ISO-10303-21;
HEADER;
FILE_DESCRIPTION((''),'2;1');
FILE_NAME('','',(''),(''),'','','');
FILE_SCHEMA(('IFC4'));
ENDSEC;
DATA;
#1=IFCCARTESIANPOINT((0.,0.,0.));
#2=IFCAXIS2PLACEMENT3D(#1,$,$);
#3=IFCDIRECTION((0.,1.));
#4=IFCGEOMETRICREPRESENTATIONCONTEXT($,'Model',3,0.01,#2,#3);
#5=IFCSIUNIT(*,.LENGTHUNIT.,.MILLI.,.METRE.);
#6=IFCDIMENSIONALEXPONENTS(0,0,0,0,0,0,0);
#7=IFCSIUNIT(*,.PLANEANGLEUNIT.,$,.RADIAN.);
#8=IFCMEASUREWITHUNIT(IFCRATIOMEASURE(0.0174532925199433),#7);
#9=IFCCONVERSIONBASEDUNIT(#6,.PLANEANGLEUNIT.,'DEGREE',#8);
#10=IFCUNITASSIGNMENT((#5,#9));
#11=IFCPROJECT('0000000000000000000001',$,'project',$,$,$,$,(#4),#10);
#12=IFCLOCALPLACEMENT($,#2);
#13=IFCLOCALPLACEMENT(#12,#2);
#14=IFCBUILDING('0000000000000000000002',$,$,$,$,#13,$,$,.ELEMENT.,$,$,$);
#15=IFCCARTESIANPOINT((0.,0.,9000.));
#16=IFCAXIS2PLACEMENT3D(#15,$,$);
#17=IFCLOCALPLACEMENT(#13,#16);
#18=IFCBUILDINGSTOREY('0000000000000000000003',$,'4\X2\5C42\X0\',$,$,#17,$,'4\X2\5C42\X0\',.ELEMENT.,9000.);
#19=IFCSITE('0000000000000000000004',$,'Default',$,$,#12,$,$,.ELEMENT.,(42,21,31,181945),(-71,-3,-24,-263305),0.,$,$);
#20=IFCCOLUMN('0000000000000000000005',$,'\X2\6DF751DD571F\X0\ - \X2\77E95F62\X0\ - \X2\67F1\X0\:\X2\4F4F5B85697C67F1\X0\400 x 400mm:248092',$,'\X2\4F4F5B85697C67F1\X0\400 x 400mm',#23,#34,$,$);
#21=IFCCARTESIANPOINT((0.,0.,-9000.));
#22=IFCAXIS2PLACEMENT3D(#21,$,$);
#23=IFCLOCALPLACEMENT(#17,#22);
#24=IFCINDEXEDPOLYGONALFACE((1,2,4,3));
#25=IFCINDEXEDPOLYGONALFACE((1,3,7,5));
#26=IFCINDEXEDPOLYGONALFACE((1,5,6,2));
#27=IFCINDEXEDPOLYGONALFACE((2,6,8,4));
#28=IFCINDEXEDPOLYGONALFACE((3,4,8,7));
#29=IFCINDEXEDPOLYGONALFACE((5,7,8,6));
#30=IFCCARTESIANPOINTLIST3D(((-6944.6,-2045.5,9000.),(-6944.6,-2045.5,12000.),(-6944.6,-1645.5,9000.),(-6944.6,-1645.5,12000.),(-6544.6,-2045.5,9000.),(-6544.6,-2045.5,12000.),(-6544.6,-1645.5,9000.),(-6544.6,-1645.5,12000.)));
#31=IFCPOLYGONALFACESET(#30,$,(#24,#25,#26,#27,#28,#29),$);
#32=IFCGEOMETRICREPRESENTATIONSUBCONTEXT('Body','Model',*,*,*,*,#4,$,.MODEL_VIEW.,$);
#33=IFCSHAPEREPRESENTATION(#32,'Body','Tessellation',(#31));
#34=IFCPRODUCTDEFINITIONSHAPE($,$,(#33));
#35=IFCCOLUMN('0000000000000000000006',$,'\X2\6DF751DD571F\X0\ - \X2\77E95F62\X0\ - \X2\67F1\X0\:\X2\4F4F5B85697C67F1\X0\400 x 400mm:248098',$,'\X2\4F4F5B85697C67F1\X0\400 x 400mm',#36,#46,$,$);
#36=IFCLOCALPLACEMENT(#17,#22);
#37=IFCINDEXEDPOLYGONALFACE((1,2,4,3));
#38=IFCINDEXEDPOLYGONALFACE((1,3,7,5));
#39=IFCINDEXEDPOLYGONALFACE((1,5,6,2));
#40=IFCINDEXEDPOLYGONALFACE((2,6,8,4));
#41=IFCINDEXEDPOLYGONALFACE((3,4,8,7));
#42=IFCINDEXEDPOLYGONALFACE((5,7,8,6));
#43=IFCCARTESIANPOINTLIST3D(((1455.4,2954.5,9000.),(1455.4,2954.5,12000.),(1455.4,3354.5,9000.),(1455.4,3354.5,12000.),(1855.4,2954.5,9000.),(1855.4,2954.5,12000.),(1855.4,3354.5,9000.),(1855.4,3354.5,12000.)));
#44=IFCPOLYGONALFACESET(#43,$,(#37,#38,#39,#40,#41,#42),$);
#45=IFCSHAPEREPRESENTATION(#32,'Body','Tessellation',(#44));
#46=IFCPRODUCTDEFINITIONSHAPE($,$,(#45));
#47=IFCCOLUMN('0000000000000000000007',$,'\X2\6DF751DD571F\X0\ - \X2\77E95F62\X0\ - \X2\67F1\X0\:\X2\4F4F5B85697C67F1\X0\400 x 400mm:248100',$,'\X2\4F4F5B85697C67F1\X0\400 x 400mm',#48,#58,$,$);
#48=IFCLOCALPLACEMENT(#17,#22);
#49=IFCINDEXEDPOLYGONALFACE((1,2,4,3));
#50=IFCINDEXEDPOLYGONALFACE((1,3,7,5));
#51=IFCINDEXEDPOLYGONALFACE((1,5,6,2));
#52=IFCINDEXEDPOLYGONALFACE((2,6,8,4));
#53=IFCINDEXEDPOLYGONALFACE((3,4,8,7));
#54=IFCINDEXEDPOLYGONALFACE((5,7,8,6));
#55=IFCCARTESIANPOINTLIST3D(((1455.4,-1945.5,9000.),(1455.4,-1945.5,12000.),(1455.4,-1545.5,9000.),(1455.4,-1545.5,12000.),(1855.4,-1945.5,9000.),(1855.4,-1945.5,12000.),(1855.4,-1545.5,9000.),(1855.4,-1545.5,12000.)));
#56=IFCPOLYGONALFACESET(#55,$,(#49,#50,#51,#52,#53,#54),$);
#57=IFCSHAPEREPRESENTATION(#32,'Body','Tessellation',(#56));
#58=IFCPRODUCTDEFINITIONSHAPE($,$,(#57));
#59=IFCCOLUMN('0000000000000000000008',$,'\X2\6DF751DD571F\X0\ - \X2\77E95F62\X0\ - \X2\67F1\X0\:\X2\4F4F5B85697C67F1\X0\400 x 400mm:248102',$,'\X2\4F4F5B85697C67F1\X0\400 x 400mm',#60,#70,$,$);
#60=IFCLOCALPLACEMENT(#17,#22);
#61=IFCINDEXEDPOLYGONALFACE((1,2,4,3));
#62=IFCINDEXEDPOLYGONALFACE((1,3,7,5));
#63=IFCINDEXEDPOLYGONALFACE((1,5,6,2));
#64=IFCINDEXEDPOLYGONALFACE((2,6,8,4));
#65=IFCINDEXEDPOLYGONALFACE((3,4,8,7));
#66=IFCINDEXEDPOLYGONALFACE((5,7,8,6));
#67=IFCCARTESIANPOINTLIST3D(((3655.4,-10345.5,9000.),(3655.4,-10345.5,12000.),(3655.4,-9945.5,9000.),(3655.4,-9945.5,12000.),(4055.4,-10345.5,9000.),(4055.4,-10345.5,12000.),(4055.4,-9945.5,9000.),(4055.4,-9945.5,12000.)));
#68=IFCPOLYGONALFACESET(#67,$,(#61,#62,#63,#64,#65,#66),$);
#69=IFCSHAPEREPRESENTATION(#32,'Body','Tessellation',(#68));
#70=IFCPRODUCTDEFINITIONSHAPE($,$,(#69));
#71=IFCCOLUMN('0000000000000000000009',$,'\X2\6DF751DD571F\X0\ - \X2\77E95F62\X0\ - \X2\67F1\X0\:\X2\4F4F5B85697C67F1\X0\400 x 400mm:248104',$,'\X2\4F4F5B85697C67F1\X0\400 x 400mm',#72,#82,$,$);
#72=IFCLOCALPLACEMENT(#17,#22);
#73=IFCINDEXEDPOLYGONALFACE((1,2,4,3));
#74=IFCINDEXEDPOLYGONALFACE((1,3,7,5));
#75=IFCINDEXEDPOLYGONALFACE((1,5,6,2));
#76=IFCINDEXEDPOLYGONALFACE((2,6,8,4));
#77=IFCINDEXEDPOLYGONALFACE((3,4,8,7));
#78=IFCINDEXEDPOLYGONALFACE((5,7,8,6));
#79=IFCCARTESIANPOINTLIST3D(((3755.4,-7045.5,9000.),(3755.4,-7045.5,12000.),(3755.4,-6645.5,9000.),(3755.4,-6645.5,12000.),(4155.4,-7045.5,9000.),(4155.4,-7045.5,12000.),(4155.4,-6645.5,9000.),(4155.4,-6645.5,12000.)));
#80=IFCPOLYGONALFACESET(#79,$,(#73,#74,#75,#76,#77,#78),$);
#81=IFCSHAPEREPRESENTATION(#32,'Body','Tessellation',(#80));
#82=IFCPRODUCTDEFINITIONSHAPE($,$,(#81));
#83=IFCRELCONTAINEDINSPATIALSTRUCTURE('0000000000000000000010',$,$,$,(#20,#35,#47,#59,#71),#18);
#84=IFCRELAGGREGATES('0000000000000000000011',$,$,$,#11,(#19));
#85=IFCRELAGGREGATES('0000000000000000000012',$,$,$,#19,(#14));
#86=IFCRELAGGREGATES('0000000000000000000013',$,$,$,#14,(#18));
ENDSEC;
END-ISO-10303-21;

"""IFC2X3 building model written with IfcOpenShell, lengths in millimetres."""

from ifc_helpers import new_model, entity, si_unit, converted_unit, direction, frame, frame_2d, origin, origin_2d_with_axis, place, context, subcontext, project, spatial, rectangle, extrude, source, transform, mapped, element, save


model = new_model("IFC2X3")

# Units and contexts
model_context = context("Model", 3, precision=0.01, world=origin(), true_north=direction((0.0, 1.0)))
body_context = subcontext(model_context, "Body", "Model", "MODEL_VIEW")
ifc_project = project(units=[si_unit("LENGTHUNIT", "METRE", prefix="MILLI"), converted_unit("PLANEANGLEUNIT", "DEGREE", entity("IfcRatioMeasure", 0.0174532925199433), si_unit("PLANEANGLEUNIT", "RADIAN"), dimensions=[0, 0, 0, 0, 0, 0, 0])], contexts=[model_context])

# Site, building, storey
site_placement = place(None, origin())
site = spatial("IfcSite", under=ifc_project, at=site_placement, Name="Default", CompositionType="ELEMENT", RefLatitude=(42, 21, 31, 181945), RefLongitude=(-71, -3, -24, -263305), RefElevation=0.0)
building_placement = place(site_placement, origin())
building = spatial("IfcBuilding", under=site, at=building_placement, CompositionType="ELEMENT")
storey_placement = place(building_placement, frame((0.0, 0.0, 9000.0)))
storey = spatial("IfcBuildingStorey", under=building, at=storey_placement, Name="4层", LongName="4层", CompositionType="ELEMENT", Elevation=9000.0)

# Columns
shared_shape_1 = source(origin(), body_context, "Body", "SweptSolid", [
    extrude(rectangle(XDim=400.0, YDim=400.0, at=origin_2d_with_axis()), frame((-6744.6, -1845.5, 9000.0), z_axis=(0.0, 0.0, 1.0), x_axis=(0.0, -1.0, 0.0)), (0.0, 0.0, 1.0), 3000.0),
])
column_1_placement = place(storey_placement, frame((0.0, 0.0, -9000.0)))
element("IfcColumn", 1, at=column_1_placement, inside=storey, Name="混凝土 - 矩形 - 柱:住宅楼柱400 x 400mm:248092", ObjectType="住宅楼柱400 x 400mm", context=body_context, shape_type="MappedRepresentation", body=[
    mapped(shared_shape_1, transform((0.0, 0.0, 0.0), scale=1.0)),
])
shared_shape_2 = source(origin(), body_context, "Body", "SweptSolid", [
    extrude(rectangle(XDim=400.0, YDim=400.0, at=origin_2d_with_axis()), frame((1655.4, 3154.5, 9000.0), z_axis=(0.0, 0.0, 1.0), x_axis=(0.0, -1.0, 0.0)), (0.0, 0.0, 1.0), 3000.0),
])
column_2_placement = place(storey_placement, frame((0.0, 0.0, -9000.0)))
element("IfcColumn", 2, at=column_2_placement, inside=storey, Name="混凝土 - 矩形 - 柱:住宅楼柱400 x 400mm:248098", ObjectType="住宅楼柱400 x 400mm", context=body_context, shape_type="MappedRepresentation", body=[
    mapped(shared_shape_2, transform((0.0, 0.0, 0.0), scale=1.0)),
])
shared_shape_3 = source(origin(), body_context, "Body", "SweptSolid", [
    extrude(rectangle(XDim=400.0, YDim=400.0, at=frame_2d((0.0, 0.0), x_axis=(1.0, 0.0))), frame((1655.4, -1745.5, 9000.0), z_axis=(0.0, 0.0, 1.0), x_axis=(0.0, -1.0, 0.0)), (0.0, 0.0, 1.0), 3000.0),
])
column_3_placement = place(storey_placement, frame((0.0, 0.0, -9000.0)))
element("IfcColumn", 3, at=column_3_placement, inside=storey, Name="混凝土 - 矩形 - 柱:住宅楼柱400 x 400mm:248100", ObjectType="住宅楼柱400 x 400mm", context=body_context, shape_type="MappedRepresentation", body=[
    mapped(shared_shape_3, transform((0.0, 0.0, 0.0), scale=1.0)),
])
shared_shape_4 = source(origin(), body_context, "Body", "SweptSolid", [
    extrude(rectangle(XDim=400.0, YDim=400.0, at=origin_2d_with_axis()), frame((3855.4, -10145.5, 9000.0), z_axis=(0.0, 0.0, 1.0), x_axis=(0.0, -1.0, 0.0)), (0.0, 0.0, 1.0), 3000.0),
])
column_4_placement = place(storey_placement, frame((0.0, 0.0, -9000.0)))
element("IfcColumn", 4, at=column_4_placement, inside=storey, Name="混凝土 - 矩形 - 柱:住宅楼柱400 x 400mm:248102", ObjectType="住宅楼柱400 x 400mm", context=body_context, shape_type="MappedRepresentation", body=[
    mapped(shared_shape_4, transform((0.0, 0.0, 0.0), scale=1.0)),
])
shared_shape_5 = source(origin(), body_context, "Body", "SweptSolid", [
    extrude(rectangle(XDim=400.0, YDim=400.0, at=origin_2d_with_axis()), frame((3955.4, -6845.5, 9000.0), z_axis=(0.0, 0.0, 1.0), x_axis=(0.0, -1.0, 0.0)), (0.0, 0.0, 1.0), 3000.0),
])
column_5_placement = place(storey_placement, frame((0.0, 0.0, -9000.0)))
element("IfcColumn", 5, at=column_5_placement, inside=storey, Name="混凝土 - 矩形 - 柱:住宅楼柱400 x 400mm:248104", ObjectType="住宅楼柱400 x 400mm", context=body_context, shape_type="MappedRepresentation", body=[
    mapped(shared_shape_5, transform((0.0, 0.0, 0.0), scale=1.0)),
])

save(model, "model.ifc")
